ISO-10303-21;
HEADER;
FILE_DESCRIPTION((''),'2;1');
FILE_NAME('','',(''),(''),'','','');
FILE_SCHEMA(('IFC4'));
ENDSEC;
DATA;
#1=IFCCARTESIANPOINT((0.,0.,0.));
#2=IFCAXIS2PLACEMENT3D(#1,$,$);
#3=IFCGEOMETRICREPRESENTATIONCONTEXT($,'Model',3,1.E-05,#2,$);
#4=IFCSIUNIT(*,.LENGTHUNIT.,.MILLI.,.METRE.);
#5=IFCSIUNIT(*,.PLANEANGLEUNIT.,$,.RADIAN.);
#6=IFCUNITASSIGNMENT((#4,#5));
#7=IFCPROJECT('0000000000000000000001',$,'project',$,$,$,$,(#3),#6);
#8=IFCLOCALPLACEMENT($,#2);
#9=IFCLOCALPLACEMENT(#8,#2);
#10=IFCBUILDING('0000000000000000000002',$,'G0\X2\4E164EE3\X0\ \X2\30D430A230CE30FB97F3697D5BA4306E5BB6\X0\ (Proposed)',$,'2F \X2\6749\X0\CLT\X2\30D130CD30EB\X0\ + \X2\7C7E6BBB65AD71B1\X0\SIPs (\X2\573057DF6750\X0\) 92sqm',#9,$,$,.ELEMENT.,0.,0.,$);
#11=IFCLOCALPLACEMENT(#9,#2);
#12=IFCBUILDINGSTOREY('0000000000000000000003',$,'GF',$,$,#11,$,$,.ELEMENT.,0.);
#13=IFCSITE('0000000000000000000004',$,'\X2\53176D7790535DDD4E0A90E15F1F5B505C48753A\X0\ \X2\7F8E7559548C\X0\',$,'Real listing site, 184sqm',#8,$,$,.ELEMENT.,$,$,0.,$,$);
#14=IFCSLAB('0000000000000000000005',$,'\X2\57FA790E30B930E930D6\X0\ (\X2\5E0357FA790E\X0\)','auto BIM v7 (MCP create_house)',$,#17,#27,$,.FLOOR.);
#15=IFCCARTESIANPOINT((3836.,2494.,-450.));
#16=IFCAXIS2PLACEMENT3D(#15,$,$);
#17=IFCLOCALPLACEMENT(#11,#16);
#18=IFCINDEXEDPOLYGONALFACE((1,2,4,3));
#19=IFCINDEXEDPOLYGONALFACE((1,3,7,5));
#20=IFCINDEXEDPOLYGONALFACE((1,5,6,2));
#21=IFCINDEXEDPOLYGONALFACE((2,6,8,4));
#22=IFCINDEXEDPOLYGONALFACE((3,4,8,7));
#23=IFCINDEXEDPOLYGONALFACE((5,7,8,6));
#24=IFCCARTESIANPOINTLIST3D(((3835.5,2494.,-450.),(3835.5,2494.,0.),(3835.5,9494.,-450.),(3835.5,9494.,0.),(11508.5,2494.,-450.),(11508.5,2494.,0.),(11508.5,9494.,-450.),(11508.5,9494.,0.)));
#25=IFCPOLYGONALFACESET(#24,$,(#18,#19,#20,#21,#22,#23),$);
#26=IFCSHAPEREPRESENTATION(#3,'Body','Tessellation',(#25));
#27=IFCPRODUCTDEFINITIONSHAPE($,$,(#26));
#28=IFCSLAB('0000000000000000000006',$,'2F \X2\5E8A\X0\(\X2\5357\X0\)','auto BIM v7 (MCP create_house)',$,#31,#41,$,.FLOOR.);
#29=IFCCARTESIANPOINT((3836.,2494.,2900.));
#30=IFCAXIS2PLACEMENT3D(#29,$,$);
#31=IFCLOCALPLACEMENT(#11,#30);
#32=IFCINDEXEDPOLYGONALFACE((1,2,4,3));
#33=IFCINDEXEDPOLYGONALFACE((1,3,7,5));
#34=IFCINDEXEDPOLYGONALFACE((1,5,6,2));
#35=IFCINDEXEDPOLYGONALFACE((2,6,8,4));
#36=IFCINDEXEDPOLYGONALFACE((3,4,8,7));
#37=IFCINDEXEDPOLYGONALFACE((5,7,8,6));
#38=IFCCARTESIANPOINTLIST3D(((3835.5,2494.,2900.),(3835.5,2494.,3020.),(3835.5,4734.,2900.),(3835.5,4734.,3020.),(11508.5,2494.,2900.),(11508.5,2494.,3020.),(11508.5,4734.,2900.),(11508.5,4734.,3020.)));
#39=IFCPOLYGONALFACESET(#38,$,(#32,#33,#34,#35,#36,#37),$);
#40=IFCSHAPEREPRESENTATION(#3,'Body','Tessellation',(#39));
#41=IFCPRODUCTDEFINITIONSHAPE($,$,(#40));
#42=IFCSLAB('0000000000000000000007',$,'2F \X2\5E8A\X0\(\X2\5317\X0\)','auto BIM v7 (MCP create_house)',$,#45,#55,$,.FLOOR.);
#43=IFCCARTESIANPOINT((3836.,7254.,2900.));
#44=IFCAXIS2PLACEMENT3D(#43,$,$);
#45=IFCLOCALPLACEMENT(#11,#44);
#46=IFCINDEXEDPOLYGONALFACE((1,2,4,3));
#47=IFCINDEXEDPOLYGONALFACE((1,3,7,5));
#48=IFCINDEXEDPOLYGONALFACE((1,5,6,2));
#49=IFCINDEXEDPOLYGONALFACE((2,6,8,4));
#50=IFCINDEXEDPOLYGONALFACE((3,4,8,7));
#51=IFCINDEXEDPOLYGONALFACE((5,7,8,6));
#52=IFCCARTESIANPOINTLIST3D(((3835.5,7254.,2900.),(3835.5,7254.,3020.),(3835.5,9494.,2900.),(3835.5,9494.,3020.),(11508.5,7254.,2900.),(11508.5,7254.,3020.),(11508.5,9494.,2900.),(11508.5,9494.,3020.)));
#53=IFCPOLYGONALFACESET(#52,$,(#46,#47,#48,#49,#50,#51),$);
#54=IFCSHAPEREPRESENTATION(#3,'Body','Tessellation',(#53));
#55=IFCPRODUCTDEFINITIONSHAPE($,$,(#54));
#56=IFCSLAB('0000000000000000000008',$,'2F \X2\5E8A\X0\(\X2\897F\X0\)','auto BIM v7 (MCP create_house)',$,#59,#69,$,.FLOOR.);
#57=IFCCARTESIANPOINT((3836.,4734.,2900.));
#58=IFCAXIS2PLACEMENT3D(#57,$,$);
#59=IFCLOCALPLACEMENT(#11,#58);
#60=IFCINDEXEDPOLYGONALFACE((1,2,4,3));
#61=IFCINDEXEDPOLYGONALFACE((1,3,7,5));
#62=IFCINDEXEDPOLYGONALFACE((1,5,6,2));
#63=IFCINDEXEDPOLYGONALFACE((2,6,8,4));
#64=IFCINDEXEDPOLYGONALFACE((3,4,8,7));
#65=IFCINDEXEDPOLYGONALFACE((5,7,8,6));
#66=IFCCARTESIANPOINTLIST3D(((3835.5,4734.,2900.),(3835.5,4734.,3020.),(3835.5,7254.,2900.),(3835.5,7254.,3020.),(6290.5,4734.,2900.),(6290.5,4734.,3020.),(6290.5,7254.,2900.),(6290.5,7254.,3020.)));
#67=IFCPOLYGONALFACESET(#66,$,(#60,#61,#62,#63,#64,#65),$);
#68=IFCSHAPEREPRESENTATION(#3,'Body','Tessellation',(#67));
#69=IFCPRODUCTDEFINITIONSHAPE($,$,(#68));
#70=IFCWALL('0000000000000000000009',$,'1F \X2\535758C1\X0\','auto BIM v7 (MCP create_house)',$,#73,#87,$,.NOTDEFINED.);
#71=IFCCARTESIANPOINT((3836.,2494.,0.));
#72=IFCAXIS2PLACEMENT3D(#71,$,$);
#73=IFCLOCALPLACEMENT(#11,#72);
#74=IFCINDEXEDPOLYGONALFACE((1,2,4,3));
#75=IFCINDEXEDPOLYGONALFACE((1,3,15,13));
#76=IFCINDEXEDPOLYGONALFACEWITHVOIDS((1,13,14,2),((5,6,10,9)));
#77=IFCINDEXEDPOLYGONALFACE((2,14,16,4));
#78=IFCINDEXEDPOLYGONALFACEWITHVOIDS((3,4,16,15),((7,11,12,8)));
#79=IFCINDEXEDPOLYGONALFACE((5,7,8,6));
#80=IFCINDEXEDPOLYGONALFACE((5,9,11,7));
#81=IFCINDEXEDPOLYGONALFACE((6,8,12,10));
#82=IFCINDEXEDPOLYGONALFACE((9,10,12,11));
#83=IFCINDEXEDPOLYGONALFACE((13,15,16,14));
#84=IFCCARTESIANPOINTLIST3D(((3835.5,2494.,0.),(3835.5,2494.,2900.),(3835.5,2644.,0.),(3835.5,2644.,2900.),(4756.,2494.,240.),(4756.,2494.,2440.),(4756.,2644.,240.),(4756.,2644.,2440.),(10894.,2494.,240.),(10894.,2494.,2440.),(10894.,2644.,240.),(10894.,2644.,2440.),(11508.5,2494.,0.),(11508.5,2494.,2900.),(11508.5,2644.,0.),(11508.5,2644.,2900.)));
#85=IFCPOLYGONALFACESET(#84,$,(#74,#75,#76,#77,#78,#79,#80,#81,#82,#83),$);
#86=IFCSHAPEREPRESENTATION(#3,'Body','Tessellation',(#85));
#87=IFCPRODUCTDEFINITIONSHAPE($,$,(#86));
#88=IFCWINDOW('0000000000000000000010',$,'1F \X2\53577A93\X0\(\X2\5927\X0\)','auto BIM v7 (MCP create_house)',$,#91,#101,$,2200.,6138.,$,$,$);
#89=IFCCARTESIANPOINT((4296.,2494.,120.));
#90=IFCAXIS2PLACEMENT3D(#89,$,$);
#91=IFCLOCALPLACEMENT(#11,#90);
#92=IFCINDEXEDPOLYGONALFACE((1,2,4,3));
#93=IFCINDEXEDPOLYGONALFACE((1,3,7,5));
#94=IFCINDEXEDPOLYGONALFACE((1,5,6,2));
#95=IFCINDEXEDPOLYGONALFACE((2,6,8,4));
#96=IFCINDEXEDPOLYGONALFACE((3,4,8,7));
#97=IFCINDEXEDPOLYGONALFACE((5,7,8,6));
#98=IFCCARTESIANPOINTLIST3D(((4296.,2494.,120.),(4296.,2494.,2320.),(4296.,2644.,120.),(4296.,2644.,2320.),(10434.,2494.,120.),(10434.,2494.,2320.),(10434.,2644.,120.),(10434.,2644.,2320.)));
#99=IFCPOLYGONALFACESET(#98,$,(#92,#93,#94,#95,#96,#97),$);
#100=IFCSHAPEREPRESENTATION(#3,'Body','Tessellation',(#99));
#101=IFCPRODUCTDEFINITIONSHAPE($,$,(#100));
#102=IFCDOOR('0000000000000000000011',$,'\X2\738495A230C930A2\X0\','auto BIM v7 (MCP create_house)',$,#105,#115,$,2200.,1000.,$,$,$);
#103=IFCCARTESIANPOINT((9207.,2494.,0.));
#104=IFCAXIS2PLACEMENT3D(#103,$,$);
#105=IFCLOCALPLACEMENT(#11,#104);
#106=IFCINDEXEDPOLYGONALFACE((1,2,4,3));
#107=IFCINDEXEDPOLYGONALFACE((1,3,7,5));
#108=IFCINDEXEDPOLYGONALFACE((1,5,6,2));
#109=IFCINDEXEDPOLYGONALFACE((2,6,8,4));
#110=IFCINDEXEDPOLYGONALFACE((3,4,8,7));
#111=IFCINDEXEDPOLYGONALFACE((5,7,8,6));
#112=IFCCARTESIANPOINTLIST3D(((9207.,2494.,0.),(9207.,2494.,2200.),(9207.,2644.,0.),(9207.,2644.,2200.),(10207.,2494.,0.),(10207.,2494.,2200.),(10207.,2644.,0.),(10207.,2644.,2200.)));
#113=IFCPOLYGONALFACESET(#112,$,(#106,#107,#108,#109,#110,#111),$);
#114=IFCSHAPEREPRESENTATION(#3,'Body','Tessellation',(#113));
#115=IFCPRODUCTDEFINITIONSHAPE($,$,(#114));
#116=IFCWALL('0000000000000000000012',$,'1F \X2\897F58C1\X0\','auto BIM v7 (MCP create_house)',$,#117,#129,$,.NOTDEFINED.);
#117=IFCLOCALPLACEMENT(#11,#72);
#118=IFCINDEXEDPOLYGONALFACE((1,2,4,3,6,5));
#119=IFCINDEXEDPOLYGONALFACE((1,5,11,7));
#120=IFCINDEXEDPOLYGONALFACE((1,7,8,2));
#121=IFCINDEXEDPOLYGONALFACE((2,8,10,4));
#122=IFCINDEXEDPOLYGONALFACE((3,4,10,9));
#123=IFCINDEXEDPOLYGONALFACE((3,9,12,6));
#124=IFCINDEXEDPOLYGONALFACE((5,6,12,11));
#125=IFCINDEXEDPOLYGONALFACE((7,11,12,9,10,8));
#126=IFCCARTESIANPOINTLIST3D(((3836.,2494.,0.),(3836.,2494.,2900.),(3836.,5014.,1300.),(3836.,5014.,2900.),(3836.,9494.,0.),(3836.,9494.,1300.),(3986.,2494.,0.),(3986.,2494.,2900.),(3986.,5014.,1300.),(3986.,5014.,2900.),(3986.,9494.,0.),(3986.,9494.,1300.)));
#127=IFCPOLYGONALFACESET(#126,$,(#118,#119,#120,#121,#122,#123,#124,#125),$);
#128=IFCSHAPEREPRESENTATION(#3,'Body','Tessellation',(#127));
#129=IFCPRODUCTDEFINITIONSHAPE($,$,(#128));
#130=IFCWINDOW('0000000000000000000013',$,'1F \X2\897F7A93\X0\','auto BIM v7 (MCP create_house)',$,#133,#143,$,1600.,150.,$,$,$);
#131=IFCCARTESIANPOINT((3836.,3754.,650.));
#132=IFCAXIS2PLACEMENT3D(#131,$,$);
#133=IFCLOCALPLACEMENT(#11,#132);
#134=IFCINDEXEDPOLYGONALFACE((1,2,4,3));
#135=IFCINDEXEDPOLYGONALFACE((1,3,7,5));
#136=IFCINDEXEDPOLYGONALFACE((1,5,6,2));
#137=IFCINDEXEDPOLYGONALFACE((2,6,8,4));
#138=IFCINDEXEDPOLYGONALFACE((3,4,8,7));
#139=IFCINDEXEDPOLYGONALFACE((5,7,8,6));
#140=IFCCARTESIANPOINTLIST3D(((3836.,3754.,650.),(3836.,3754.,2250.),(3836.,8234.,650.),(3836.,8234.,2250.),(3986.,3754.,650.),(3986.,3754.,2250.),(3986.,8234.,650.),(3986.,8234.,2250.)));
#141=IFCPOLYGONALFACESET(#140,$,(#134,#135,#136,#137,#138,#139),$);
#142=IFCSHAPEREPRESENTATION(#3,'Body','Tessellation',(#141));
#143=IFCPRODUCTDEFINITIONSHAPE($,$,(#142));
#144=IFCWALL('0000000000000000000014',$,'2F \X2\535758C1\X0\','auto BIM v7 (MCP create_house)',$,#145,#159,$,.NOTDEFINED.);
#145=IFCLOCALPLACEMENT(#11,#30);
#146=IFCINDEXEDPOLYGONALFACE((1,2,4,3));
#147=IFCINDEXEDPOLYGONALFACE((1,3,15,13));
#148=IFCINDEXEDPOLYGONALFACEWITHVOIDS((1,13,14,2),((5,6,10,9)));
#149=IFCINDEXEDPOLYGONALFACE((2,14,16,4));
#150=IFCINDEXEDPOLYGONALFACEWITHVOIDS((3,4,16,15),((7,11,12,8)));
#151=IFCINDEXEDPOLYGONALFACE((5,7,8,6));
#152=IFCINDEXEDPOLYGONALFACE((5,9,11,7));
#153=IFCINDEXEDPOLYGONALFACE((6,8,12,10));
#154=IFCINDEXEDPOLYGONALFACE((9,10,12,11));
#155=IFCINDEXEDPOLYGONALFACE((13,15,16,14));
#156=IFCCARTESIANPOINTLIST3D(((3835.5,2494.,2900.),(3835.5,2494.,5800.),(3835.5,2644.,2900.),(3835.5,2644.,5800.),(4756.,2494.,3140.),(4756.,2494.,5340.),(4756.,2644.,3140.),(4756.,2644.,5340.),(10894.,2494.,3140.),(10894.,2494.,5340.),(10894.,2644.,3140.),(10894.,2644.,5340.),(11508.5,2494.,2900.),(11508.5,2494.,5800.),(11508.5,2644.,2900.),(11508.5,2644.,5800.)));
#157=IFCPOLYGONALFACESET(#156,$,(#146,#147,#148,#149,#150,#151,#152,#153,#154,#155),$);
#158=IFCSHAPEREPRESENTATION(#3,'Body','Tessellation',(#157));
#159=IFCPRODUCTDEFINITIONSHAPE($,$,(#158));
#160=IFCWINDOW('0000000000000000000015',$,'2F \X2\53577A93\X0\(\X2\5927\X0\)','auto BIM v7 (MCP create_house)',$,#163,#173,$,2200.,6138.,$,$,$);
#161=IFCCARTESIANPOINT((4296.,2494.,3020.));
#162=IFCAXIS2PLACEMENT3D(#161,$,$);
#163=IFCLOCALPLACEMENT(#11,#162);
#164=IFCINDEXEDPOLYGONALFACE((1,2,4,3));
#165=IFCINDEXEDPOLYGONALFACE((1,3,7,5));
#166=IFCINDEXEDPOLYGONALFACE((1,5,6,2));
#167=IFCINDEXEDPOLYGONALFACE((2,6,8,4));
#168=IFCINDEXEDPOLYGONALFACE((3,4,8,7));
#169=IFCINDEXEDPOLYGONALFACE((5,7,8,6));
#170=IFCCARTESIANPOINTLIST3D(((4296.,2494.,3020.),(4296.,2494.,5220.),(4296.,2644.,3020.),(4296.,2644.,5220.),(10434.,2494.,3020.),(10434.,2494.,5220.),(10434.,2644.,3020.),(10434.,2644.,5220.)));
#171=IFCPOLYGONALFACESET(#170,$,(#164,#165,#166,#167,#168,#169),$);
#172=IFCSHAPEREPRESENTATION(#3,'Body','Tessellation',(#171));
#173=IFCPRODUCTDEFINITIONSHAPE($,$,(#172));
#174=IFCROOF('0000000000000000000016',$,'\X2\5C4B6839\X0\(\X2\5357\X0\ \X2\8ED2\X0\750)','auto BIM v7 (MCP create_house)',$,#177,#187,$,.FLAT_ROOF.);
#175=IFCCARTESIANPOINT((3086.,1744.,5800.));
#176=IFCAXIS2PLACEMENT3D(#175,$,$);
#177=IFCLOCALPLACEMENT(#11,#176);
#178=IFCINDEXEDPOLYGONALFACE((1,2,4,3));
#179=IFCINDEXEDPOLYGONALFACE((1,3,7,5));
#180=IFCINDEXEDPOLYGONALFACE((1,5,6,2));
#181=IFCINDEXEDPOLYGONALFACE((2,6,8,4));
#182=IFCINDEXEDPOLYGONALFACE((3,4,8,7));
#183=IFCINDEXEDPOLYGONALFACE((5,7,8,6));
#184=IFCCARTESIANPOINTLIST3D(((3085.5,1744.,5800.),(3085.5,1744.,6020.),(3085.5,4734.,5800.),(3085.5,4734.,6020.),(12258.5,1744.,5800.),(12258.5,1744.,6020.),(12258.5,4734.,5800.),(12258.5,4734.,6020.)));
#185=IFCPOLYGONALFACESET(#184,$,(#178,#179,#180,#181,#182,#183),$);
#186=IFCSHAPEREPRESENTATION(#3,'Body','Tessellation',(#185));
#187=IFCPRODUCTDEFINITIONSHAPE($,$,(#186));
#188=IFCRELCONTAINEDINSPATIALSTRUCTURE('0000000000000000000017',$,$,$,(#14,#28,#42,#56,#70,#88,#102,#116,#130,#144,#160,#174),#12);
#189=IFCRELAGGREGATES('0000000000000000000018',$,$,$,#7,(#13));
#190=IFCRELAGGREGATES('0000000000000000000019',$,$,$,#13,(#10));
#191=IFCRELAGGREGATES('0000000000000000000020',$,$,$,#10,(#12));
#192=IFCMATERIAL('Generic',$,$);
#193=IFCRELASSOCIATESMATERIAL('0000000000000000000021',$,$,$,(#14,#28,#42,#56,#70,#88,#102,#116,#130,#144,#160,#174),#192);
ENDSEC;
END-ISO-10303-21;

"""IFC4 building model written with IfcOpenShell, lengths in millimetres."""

from ifc_helpers import new_model, si_unit, frame, frame_2d, origin, place, context, project, spatial, rectangle, extrude, material, element, fill, save


model = new_model("IFC4")

# Units and contexts
model_context = context("Model", 3, precision=1e-05, world=origin())
ifc_project = project(units=[si_unit("LENGTHUNIT", "METRE", prefix="MILLI"), si_unit("PLANEANGLEUNIT", "RADIAN")], contexts=[model_context])

# Site, building, storey
site_placement = place(None, origin())
site = spatial("IfcSite", under=ifc_project, at=site_placement, Name="北海道川上郡弟子屈町 美留和", ObjectType="Real listing site, 184sqm", CompositionType="ELEMENT", RefElevation=0.0)
building_placement = place(site_placement, origin())
building = spatial("IfcBuilding", under=site, at=building_placement, Name="G0世代 ピアノ・音楽室の家 (Proposed)", ObjectType="2F 杉CLTパネル + 籾殻断熱SIPs (地域材) 92sqm", CompositionType="ELEMENT", ElevationOfRefHeight=0.0, ElevationOfTerrain=0.0)
storey_placement = place(building_placement, origin())
storey = spatial("IfcBuildingStorey", under=building, at=storey_placement, Name="GF", CompositionType="ELEMENT", Elevation=0.0)

# Slabs
ifc_material = material(Name="Generic")
slab_1_placement = place(storey_placement, frame((3836.0, 2494.0, -450.0)))
element("IfcSlab", 1, at=slab_1_placement, inside=storey, material=ifc_material, Name="基礎スラブ (布基礎)", Description="auto BIM v7 (MCP create_house)", PredefinedType="FLOOR", context=model_context, shape_type="SweptSolid", body=[
    extrude(rectangle(XDim=7673.0, YDim=7000.0, at=frame_2d((3836.0, 3500.0))), frame((3836.0, 2494.0, -450.0)), (0.0, 0.0, 1.0), 450.0),
])
slab_2_placement = place(storey_placement, frame((3836.0, 2494.0, 2900.0)))
element("IfcSlab", 2, at=slab_2_placement, inside=storey, material=ifc_material, Name="2F 床(南)", Description="auto BIM v7 (MCP create_house)", PredefinedType="FLOOR", context=model_context, shape_type="SweptSolid", body=[
    extrude(rectangle(XDim=7673.0, YDim=2240.0, at=frame_2d((3836.0, 1120.0))), frame((3836.0, 2494.0, 2900.0)), (0.0, 0.0, 1.0), 120.0),
])
slab_3_placement = place(storey_placement, frame((3836.0, 7254.0, 2900.0)))
element("IfcSlab", 3, at=slab_3_placement, inside=storey, material=ifc_material, Name="2F 床(北)", Description="auto BIM v7 (MCP create_house)", PredefinedType="FLOOR", context=model_context, shape_type="SweptSolid", body=[
    extrude(rectangle(XDim=7673.0, YDim=2240.0, at=frame_2d((3836.0, 1120.0))), frame((3836.0, 7254.0, 2900.0)), (0.0, 0.0, 1.0), 120.0),
])
slab_4_placement = place(storey_placement, frame((3836.0, 4734.0, 2900.0)))
element("IfcSlab", 4, at=slab_4_placement, inside=storey, material=ifc_material, Name="2F 床(西)", Description="auto BIM v7 (MCP create_house)", PredefinedType="FLOOR", context=model_context, shape_type="SweptSolid", body=[
    extrude(rectangle(XDim=2455.0, YDim=2520.0, at=frame_2d((1227.0, 1260.0))), frame((3836.0, 4734.0, 2900.0)), (0.0, 0.0, 1.0), 120.0),
])

# Wall, openings, window, door
wall_1_placement = place(storey_placement, frame((3836.0, 2494.0, 0.0)))
wall_1 = element("IfcWall", 5, at=wall_1_placement, inside=storey, material=ifc_material, Name="1F 南壁", Description="auto BIM v7 (MCP create_house)", PredefinedType="NOTDEFINED", context=model_context, shape_type="SweptSolid", body=[
    extrude(rectangle(XDim=7673.0, YDim=150.0, at=frame_2d((3836.0, 75.0))), frame((3836.0, 2494.0, 0.0)), (0.0, 0.0, 1.0), 2900.0),
])
opening_1_placement = place(storey_placement, frame((4296.0, 2494.0, 120.0)))
opening_1 = element("IfcOpeningElement", 6, at=opening_1_placement, cuts=wall_1, PredefinedType="NOTDEFINED", context=model_context, shape_type="SweptSolid", body=[
    extrude(rectangle(XDim=6138.0, YDim=150.0, at=frame_2d((3069.0, 75.0))), frame((4296.0, 2494.0, 120.0)), (0.0, 0.0, 1.0), 2200.0),
])
opening_2_placement = place(storey_placement, frame((9207.0, 2494.0, 0.0)))
opening_2 = element("IfcOpeningElement", 7, at=opening_2_placement, cuts=wall_1, PredefinedType="NOTDEFINED", context=model_context, shape_type="SweptSolid", body=[
    extrude(rectangle(XDim=1000.0, YDim=150.0, at=frame_2d((500.0, 75.0))), frame((9207.0, 2494.0, 0.0)), (0.0, 0.0, 1.0), 2200.0),
])
window_1_placement = place(storey_placement, frame((4296.0, 2494.0, 120.0)))
window_1 = element("IfcWindow", 8, at=window_1_placement, inside=storey, material=ifc_material, Name="1F 南窓(大)", Description="auto BIM v7 (MCP create_house)", OverallHeight=2200.0, OverallWidth=6138.0, context=model_context, shape_type="SweptSolid", body=[
    extrude(rectangle(XDim=6138.0, YDim=150.0, at=frame_2d((3069.0, 75.0))), frame((4296.0, 2494.0, 120.0)), (0.0, 0.0, 1.0), 2200.0),
])
fill(opening_1, window_1)
door_placement = place(storey_placement, frame((9207.0, 2494.0, 0.0)))
door = element("IfcDoor", 9, at=door_placement, inside=storey, material=ifc_material, Name="玄関ドア", Description="auto BIM v7 (MCP create_house)", OverallHeight=2200.0, OverallWidth=1000.0, context=model_context, shape_type="SweptSolid", body=[
    extrude(rectangle(XDim=1000.0, YDim=150.0, at=frame_2d((500.0, 75.0))), frame((9207.0, 2494.0, 0.0)), (0.0, 0.0, 1.0), 2200.0),
])
fill(opening_2, door)

# Walls, openings, windows
wall_2_placement = place(storey_placement, frame((3836.0, 2494.0, 0.0)))
wall_2 = element("IfcWall", 10, at=wall_2_placement, inside=storey, material=ifc_material, Name="1F 西壁", Description="auto BIM v7 (MCP create_house)", PredefinedType="NOTDEFINED", context=model_context, shape_type="SweptSolid", body=[
    extrude(rectangle(XDim=150.0, YDim=7000.0, at=frame_2d((75.0, 3500.0))), frame((3836.0, 2494.0, 0.0)), (0.0, 0.0, 1.0), 2900.0),
])
opening_3_placement = place(storey_placement, frame((3836.0, 3754.0, 650.0)))
opening_3 = element("IfcOpeningElement", 11, at=opening_3_placement, cuts=wall_2, PredefinedType="NOTDEFINED", context=model_context, shape_type="SweptSolid", body=[
    extrude(rectangle(XDim=150.0, YDim=4480.0, at=frame_2d((75.0, 2240.0))), frame((3836.0, 3754.0, 650.0)), (0.0, 0.0, 1.0), 1600.0),
])
window_2_placement = place(storey_placement, frame((3836.0, 3754.0, 650.0)))
window_2 = element("IfcWindow", 12, at=window_2_placement, inside=storey, material=ifc_material, Name="1F 西窓", Description="auto BIM v7 (MCP create_house)", OverallHeight=1600.0, OverallWidth=150.0, context=model_context, shape_type="SweptSolid", body=[
    extrude(rectangle(XDim=150.0, YDim=4480.0, at=frame_2d((75.0, 2240.0))), frame((3836.0, 3754.0, 650.0)), (0.0, 0.0, 1.0), 1600.0),
])
fill(opening_3, window_2)
wall_3_placement = place(storey_placement, frame((3836.0, 2494.0, 2900.0)))
wall_3 = element("IfcWall", 13, at=wall_3_placement, inside=storey, material=ifc_material, Name="2F 南壁", Description="auto BIM v7 (MCP create_house)", PredefinedType="NOTDEFINED", context=model_context, shape_type="SweptSolid", body=[
    extrude(rectangle(XDim=7673.0, YDim=150.0, at=frame_2d((3836.0, 75.0))), frame((3836.0, 2494.0, 2900.0)), (0.0, 0.0, 1.0), 2900.0),
])
opening_4_placement = place(storey_placement, frame((4296.0, 2494.0, 3020.0)))
opening_4 = element("IfcOpeningElement", 14, at=opening_4_placement, cuts=wall_3, PredefinedType="NOTDEFINED", context=model_context, shape_type="SweptSolid", body=[
    extrude(rectangle(XDim=6138.0, YDim=150.0, at=frame_2d((3069.0, 75.0))), frame((4296.0, 2494.0, 3020.0)), (0.0, 0.0, 1.0), 2200.0),
])
window_3_placement = place(storey_placement, frame((4296.0, 2494.0, 3020.0)))
window_3 = element("IfcWindow", 15, at=window_3_placement, inside=storey, material=ifc_material, Name="2F 南窓(大)", Description="auto BIM v7 (MCP create_house)", OverallHeight=2200.0, OverallWidth=6138.0, context=model_context, shape_type="SweptSolid", body=[
    extrude(rectangle(XDim=6138.0, YDim=150.0, at=frame_2d((3069.0, 75.0))), frame((4296.0, 2494.0, 3020.0)), (0.0, 0.0, 1.0), 2200.0),
])
fill(opening_4, window_3)

# Roof
roof_1_placement = place(storey_placement, frame((3086.0, 1744.0, 5800.0)))
element("IfcRoof", 16, at=roof_1_placement, inside=storey, material=ifc_material, Name="屋根(南 軒750)", Description="auto BIM v7 (MCP create_house)", PredefinedType="FLAT_ROOF", context=model_context, shape_type="SweptSolid", body=[
    extrude(rectangle(XDim=9173.0, YDim=2990.0, at=frame_2d((4586.0, 1495.0))), frame((3086.0, 1744.0, 5800.0)), (0.0, 0.0, 1.0), 220.0),
])

save(model, "model.ifc")
